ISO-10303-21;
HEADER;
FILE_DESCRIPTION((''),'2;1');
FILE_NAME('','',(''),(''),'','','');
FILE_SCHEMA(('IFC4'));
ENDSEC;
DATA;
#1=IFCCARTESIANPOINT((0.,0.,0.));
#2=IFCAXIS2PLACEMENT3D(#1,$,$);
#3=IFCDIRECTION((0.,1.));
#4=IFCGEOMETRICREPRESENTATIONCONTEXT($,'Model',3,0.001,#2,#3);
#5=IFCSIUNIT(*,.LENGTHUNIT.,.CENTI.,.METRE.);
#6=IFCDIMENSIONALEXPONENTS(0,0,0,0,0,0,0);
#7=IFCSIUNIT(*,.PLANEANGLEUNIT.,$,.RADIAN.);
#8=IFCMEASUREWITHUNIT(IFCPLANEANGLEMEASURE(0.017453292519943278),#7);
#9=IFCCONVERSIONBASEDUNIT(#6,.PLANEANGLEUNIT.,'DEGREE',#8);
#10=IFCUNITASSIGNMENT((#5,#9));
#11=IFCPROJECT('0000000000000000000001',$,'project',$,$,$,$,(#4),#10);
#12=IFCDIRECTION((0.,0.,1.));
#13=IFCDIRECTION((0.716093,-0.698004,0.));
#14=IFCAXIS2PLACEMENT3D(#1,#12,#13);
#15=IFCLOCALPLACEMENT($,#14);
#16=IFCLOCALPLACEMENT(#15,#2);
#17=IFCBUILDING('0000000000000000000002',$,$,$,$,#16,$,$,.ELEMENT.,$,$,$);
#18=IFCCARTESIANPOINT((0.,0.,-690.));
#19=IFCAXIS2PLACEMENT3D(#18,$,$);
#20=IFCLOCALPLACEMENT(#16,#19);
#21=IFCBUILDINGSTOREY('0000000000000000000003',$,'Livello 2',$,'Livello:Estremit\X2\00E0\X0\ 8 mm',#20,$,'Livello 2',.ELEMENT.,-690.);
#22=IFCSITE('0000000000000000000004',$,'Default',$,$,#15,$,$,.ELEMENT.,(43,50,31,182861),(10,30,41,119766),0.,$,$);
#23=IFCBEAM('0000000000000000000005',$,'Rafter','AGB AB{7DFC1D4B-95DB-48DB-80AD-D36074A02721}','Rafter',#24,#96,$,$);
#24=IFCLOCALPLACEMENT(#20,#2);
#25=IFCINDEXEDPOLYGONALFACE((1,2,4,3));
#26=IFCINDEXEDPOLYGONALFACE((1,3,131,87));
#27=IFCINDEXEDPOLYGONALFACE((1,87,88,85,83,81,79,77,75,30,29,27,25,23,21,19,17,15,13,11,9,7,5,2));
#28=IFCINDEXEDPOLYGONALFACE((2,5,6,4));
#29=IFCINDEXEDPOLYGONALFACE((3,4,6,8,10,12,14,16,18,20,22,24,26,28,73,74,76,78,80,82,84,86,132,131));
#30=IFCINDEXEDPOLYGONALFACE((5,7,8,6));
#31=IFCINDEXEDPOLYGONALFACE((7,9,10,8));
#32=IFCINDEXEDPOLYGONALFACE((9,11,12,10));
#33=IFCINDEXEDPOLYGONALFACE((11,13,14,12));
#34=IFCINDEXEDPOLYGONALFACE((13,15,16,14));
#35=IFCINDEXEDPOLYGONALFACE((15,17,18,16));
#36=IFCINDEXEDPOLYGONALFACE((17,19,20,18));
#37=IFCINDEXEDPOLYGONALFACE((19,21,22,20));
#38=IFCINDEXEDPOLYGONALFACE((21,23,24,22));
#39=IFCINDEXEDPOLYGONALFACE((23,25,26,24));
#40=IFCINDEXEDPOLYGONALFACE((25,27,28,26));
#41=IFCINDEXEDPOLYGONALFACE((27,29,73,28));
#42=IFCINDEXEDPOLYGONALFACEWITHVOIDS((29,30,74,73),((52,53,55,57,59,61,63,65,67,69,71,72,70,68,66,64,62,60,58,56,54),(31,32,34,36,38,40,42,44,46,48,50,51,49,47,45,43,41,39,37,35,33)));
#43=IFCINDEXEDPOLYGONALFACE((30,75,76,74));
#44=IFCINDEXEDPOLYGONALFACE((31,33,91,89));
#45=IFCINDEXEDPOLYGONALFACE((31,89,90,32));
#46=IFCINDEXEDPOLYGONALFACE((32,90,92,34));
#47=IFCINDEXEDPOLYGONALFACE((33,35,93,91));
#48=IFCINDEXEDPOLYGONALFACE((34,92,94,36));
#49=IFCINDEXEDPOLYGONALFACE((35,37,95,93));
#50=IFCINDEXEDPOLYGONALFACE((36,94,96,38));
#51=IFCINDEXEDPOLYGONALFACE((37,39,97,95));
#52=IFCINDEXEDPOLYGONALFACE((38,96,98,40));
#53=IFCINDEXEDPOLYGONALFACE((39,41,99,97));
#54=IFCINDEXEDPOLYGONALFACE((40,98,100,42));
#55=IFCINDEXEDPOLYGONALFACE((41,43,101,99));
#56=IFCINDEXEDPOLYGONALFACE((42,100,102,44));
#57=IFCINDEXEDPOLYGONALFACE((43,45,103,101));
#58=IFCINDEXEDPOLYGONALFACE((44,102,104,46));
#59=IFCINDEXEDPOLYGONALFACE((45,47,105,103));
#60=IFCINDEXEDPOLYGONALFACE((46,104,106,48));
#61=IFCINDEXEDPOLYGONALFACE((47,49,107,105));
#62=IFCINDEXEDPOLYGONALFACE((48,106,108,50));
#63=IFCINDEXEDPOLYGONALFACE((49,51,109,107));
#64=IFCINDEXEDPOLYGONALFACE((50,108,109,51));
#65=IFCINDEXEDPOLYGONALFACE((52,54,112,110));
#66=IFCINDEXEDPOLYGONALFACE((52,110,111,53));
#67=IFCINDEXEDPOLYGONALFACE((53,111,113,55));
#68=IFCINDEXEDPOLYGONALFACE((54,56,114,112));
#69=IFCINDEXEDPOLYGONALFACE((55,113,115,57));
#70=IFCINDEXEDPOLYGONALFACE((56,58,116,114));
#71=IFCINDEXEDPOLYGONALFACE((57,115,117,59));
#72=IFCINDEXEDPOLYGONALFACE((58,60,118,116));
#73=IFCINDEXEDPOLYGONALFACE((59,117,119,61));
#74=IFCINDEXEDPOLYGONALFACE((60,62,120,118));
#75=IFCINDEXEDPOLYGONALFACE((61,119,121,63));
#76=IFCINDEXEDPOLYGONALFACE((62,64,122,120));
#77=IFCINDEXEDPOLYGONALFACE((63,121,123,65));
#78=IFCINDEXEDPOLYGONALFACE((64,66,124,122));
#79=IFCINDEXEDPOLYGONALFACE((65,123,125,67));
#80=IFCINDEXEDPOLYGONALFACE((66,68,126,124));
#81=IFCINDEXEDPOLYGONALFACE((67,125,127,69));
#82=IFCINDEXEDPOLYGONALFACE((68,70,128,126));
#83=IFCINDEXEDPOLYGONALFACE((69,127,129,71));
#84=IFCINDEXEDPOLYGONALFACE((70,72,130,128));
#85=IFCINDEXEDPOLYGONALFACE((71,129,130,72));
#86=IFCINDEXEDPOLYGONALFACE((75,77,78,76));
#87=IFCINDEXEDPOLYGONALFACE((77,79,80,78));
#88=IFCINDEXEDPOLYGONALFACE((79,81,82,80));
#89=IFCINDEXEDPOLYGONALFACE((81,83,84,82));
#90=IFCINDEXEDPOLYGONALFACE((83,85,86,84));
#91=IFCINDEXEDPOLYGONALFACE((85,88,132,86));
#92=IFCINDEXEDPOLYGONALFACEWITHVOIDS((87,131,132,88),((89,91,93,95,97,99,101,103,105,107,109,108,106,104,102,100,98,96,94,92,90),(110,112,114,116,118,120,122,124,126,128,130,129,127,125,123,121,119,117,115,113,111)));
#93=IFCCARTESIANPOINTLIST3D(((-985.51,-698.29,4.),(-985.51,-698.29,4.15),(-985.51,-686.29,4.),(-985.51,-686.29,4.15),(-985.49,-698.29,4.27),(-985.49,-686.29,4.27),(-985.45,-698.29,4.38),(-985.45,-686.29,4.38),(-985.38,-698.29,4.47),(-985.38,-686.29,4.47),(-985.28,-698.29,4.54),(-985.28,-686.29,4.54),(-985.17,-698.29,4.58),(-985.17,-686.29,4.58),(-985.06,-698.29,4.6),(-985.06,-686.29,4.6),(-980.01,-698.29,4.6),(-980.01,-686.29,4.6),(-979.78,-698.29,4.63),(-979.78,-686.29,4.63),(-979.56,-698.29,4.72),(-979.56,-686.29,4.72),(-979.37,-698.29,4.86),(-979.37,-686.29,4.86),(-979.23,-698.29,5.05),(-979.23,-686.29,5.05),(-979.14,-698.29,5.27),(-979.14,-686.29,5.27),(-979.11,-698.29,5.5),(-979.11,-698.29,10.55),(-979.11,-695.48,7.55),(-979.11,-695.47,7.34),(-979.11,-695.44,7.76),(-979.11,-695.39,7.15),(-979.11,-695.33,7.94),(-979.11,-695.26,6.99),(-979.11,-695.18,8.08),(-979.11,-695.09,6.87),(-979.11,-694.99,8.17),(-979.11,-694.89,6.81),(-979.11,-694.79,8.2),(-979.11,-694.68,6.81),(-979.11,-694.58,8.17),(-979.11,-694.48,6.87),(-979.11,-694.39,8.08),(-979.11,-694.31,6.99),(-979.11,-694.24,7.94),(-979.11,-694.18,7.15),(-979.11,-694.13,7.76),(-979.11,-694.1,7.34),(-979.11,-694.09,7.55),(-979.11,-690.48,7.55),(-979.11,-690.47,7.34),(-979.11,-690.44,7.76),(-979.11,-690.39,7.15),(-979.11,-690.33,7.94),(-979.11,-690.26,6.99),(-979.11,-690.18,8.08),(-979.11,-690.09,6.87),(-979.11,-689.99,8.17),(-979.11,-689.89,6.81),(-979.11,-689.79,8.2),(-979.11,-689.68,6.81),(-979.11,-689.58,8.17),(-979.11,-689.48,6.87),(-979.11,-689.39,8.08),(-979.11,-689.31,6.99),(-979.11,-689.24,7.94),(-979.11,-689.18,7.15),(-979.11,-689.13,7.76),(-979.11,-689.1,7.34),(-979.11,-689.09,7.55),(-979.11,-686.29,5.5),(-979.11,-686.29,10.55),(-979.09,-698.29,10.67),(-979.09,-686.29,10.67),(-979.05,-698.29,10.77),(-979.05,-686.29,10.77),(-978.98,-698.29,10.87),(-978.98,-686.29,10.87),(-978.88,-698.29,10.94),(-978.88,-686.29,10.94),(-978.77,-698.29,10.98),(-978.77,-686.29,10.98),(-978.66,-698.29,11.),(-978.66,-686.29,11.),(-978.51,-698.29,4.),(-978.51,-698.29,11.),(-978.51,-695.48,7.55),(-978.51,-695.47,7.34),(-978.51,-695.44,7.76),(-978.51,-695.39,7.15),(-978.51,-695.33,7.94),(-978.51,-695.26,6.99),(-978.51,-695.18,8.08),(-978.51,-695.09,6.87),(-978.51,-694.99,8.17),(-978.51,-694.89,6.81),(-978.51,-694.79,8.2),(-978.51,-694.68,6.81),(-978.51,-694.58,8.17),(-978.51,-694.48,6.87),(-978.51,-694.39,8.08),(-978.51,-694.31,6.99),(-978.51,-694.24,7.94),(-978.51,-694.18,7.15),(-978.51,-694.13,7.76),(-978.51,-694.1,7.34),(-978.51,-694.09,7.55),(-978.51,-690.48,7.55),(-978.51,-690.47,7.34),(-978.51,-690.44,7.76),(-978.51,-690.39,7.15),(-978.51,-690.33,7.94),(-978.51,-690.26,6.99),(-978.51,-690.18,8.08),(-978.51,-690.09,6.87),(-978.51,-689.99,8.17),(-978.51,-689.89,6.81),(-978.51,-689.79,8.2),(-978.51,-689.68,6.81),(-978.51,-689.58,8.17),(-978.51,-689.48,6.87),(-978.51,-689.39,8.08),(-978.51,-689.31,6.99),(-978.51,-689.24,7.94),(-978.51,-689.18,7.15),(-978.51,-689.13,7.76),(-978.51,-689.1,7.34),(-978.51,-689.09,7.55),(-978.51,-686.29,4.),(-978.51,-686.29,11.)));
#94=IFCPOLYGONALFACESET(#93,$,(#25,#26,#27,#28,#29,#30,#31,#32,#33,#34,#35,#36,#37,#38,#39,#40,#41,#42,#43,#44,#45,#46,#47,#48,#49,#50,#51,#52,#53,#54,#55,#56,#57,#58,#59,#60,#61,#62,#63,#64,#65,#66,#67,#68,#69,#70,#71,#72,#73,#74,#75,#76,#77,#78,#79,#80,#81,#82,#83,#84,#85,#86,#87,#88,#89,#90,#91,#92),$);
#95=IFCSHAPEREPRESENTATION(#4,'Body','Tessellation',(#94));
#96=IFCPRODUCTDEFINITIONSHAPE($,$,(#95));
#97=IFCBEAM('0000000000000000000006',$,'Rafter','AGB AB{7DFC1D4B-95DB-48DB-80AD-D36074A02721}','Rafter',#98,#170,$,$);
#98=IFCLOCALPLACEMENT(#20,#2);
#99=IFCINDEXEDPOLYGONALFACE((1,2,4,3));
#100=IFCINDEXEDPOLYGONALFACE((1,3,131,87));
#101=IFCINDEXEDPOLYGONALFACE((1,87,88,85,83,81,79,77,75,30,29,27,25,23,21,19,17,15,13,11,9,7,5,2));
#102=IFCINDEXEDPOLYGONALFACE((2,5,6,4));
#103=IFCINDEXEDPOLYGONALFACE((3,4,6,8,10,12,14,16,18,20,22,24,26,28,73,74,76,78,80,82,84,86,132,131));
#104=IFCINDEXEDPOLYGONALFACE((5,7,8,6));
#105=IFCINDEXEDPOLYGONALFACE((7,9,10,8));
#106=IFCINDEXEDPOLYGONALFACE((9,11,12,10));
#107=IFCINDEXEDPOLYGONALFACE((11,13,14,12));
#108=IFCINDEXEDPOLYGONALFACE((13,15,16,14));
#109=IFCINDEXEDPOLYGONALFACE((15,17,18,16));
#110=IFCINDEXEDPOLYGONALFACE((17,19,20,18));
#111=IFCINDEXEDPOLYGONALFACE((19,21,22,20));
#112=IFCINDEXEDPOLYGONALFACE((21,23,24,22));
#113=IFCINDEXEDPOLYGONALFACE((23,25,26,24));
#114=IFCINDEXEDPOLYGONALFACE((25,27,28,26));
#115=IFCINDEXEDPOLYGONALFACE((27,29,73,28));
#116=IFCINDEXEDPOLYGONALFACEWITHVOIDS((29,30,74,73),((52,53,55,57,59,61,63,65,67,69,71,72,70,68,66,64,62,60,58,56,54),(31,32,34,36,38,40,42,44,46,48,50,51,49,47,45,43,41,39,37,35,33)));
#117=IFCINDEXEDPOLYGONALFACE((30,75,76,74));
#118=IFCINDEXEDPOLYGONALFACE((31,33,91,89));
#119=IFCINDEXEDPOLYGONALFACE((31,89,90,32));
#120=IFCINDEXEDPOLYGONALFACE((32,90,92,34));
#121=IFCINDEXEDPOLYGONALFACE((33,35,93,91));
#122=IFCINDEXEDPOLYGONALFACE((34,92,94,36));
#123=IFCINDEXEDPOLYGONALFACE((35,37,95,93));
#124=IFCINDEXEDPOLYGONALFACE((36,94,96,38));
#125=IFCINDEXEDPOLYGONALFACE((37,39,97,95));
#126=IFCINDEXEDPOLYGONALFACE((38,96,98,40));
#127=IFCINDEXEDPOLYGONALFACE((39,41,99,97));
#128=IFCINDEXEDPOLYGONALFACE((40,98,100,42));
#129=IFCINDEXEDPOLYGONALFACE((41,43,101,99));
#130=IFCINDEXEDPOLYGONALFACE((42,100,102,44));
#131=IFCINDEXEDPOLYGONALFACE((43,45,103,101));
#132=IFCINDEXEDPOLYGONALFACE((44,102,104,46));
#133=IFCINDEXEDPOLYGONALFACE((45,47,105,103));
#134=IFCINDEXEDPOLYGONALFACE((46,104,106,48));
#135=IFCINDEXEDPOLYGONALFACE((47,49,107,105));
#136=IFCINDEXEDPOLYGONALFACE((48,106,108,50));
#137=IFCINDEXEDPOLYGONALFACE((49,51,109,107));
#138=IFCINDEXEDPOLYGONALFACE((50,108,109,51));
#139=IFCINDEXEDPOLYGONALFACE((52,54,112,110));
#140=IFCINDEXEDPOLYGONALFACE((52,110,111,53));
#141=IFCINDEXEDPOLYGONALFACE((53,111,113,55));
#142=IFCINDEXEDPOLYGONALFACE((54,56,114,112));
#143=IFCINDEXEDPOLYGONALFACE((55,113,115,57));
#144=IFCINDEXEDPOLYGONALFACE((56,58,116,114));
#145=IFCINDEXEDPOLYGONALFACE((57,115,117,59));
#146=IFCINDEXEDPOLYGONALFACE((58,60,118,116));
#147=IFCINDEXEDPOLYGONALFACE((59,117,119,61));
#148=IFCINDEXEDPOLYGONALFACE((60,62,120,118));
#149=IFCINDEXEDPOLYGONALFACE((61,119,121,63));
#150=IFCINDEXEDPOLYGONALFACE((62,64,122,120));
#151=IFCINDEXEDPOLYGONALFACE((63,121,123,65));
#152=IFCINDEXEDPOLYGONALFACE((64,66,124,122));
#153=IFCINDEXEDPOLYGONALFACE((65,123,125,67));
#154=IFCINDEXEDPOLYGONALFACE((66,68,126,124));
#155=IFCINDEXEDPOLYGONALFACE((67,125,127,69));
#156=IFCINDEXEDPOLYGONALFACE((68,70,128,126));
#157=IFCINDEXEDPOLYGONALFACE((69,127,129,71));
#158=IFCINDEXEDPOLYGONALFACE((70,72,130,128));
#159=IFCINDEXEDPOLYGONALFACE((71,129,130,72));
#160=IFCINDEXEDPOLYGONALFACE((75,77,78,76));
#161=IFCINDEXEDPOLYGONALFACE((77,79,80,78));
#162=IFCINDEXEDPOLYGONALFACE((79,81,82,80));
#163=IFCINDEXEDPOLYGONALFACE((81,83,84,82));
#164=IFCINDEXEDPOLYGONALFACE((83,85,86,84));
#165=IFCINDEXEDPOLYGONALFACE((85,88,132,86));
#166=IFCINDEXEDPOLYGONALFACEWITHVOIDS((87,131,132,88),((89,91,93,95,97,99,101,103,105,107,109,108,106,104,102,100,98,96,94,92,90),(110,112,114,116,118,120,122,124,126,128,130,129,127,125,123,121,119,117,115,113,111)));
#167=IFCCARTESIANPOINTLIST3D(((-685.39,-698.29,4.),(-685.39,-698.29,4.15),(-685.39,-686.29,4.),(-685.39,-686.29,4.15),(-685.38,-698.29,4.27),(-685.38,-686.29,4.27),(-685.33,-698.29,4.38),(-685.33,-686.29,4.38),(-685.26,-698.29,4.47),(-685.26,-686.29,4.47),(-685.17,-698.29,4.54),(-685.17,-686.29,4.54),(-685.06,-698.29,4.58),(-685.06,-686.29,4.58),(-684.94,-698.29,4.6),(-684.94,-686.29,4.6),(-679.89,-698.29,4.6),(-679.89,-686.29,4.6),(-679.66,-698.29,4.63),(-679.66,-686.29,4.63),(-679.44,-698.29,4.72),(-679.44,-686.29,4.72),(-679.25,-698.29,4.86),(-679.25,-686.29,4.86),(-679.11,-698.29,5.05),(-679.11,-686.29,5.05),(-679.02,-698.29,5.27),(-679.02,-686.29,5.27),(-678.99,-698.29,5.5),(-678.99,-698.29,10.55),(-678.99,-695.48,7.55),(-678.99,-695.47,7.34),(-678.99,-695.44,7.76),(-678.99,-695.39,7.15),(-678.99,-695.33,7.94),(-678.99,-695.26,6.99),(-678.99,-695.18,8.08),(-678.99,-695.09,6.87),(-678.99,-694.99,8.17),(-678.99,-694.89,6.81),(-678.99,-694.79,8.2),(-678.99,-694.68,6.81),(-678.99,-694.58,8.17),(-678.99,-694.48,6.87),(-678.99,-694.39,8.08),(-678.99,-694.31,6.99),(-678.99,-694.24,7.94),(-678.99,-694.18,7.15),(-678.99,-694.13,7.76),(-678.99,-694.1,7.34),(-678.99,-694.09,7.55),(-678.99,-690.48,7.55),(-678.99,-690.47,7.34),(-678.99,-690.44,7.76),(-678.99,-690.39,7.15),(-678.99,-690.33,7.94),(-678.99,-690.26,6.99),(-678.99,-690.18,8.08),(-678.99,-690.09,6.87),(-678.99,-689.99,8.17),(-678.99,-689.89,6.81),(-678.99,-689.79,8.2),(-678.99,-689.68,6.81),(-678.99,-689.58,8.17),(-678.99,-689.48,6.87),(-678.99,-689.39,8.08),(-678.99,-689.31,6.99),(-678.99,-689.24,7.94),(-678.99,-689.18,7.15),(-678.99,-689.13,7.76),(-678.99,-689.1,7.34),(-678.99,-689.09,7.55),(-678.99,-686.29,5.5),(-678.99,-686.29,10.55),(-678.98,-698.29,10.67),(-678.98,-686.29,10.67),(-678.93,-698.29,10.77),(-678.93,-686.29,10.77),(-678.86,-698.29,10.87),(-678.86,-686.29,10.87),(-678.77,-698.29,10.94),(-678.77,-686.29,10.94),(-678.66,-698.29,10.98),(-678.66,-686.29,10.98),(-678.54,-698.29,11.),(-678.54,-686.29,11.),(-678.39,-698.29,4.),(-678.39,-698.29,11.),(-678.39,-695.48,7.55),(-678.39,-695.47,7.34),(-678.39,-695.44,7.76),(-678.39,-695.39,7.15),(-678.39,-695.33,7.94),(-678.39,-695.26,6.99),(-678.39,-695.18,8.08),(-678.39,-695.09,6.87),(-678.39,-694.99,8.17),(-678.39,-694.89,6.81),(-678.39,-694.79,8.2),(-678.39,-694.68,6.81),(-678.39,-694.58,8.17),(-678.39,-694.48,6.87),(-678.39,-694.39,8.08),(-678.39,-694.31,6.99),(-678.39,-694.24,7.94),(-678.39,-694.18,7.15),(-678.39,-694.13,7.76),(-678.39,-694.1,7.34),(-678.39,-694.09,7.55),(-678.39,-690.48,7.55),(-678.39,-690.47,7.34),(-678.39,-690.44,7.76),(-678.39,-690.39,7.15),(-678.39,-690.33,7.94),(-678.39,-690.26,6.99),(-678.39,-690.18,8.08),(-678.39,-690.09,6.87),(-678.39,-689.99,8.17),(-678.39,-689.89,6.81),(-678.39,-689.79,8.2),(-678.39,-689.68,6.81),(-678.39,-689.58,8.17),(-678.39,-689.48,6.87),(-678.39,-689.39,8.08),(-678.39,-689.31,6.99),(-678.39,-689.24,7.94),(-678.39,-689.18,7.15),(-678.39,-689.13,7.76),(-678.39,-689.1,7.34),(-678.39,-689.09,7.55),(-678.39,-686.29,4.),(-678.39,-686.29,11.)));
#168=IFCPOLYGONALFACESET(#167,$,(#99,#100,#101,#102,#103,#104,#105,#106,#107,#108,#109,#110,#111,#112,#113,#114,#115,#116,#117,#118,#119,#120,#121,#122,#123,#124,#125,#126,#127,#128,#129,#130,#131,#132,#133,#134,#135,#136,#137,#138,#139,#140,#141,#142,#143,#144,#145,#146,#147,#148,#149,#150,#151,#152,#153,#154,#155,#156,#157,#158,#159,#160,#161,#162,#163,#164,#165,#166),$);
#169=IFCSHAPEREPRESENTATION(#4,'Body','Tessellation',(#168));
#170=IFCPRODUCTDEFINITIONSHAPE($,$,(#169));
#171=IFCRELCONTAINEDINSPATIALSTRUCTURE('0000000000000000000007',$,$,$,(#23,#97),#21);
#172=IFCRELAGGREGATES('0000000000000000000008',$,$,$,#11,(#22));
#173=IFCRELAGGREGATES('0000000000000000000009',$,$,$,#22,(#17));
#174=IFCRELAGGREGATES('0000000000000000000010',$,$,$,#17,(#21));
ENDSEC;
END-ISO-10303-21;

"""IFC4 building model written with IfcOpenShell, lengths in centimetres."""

from ifc_helpers import new_model, entity, si_unit, converted_unit, direction, frame, frame_2d, origin, place, context, project, spatial, circle, l_section, extrude, element, save


model = new_model("IFC4")

# Units and contexts
model_context = context("Model", 3, precision=0.001, world=origin(), true_north=direction((0.0, 1.0)))
ifc_project = project(units=[si_unit("LENGTHUNIT", "METRE", prefix="CENTI"), converted_unit("PLANEANGLEUNIT", "DEGREE", entity("IfcPlaneAngleMeasure", 0.017453292519943278), si_unit("PLANEANGLEUNIT", "RADIAN"), dimensions=[0, 0, 0, 0, 0, 0, 0])], contexts=[model_context])

# Site, building, storey
site_placement = place(None, frame((0.0, 0.0, 0.0), z_axis=(0.0, 0.0, 1.0), x_axis=(0.716093, -0.698004, 0.0)))
site = spatial("IfcSite", under=ifc_project, at=site_placement, Name="Default", CompositionType="ELEMENT", RefLatitude=(43, 50, 31, 182861), RefLongitude=(10, 30, 41, 119766), RefElevation=0.0)
building_placement = place(site_placement, origin())
building = spatial("IfcBuilding", under=site, at=building_placement, CompositionType="ELEMENT")
storey_placement = place(building_placement, frame((0.0, 0.0, -690.0)))
storey = spatial("IfcBuildingStorey", under=building, at=storey_placement, Name="Livello 2", ObjectType="Livello:Estremità 8 mm", LongName="Livello 2", CompositionType="ELEMENT", Elevation=-690.0)

# Beams, openings
beam_1_placement = place(storey_placement, frame((-980.44, -686.29, 5.93), z_axis=(0.0, 1.0, 0.0), x_axis=(-1.0, 0.0, 0.0)))
beam_1 = element("IfcBeam", 1, at=beam_1_placement, inside=storey, Name="Rafter", Description="AGB AB{7DFC1D4B-95DB-48DB-80AD-D36074A02721}", ObjectType="Rafter", context=model_context, shape_type="SweptSolid", body=[
    extrude(l_section(Depth=7.0, Width=7.0, Thickness=0.6, FilletRadius=0.9, EdgeRadius=0.45, at=frame_2d((1.57, 1.57))), origin(), (0.0, 0.0, -1.0), 12.0),
])
opening_1_placement = place(beam_1_placement, frame((-1.28, 1.57, -7.8), z_axis=(1.0, 0.0, 0.0), x_axis=(0.0, 1.0, 0.0)))
element("IfcOpeningElement", 2, at=opening_1_placement, cuts=beam_1, ObjectType="Opening", context=model_context, shape_type="SweptSolid", body=[
    extrude(circle(Radius=0.7, at=frame_2d((0.0, -0.7), x_axis=(1.0, 0.0))), origin(), (0.0, 0.0, -1.0), 0.7),
])
opening_2_placement = place(beam_1_placement, frame((-1.28, 1.57, -2.8), z_axis=(1.0, 0.0, 0.0), x_axis=(0.0, 1.0, 0.0)))
element("IfcOpeningElement", 3, at=opening_2_placement, cuts=beam_1, ObjectType="Opening", context=model_context, shape_type="SweptSolid", body=[
    extrude(circle(Radius=0.7, at=frame_2d((0.0, -0.7), x_axis=(1.0, 0.0))), origin(), (0.0, 0.0, -1.0), 0.7),
])
beam_2_placement = place(storey_placement, frame((-680.32, -686.29, 5.93), z_axis=(0.0, 1.0, 0.0), x_axis=(-1.0, 0.0, 0.0)))
beam_2 = element("IfcBeam", 4, at=beam_2_placement, inside=storey, Name="Rafter", Description="AGB AB{7DFC1D4B-95DB-48DB-80AD-D36074A02721}", ObjectType="Rafter", context=model_context, shape_type="SweptSolid", body=[
    extrude(l_section(Depth=7.0, Width=7.0, Thickness=0.6, FilletRadius=0.9, EdgeRadius=0.45, at=frame_2d((1.57, 1.57))), origin(), (0.0, 0.0, -1.0), 12.0),
])
opening_3_placement = place(beam_2_placement, frame((-1.28, 1.57, -7.8), z_axis=(1.0, 0.0, 0.0), x_axis=(0.0, 1.0, 0.0)))
element("IfcOpeningElement", 5, at=opening_3_placement, cuts=beam_2, ObjectType="Opening", context=model_context, shape_type="SweptSolid", body=[
    extrude(circle(Radius=0.7, at=frame_2d((0.0, -0.7), x_axis=(1.0, 0.0))), origin(), (0.0, 0.0, -1.0), 0.7),
])
opening_4_placement = place(beam_2_placement, frame((-1.28, 1.57, -2.8), z_axis=(1.0, 0.0, 0.0), x_axis=(0.0, 1.0, 0.0)))
element("IfcOpeningElement", 6, at=opening_4_placement, cuts=beam_2, ObjectType="Opening", context=model_context, shape_type="SweptSolid", body=[
    extrude(circle(Radius=0.7, at=frame_2d((0.0, -0.7), x_axis=(1.0, 0.0))), origin(), (0.0, 0.0, -1.0), 0.7),
])

save(model, "model.ifc")
